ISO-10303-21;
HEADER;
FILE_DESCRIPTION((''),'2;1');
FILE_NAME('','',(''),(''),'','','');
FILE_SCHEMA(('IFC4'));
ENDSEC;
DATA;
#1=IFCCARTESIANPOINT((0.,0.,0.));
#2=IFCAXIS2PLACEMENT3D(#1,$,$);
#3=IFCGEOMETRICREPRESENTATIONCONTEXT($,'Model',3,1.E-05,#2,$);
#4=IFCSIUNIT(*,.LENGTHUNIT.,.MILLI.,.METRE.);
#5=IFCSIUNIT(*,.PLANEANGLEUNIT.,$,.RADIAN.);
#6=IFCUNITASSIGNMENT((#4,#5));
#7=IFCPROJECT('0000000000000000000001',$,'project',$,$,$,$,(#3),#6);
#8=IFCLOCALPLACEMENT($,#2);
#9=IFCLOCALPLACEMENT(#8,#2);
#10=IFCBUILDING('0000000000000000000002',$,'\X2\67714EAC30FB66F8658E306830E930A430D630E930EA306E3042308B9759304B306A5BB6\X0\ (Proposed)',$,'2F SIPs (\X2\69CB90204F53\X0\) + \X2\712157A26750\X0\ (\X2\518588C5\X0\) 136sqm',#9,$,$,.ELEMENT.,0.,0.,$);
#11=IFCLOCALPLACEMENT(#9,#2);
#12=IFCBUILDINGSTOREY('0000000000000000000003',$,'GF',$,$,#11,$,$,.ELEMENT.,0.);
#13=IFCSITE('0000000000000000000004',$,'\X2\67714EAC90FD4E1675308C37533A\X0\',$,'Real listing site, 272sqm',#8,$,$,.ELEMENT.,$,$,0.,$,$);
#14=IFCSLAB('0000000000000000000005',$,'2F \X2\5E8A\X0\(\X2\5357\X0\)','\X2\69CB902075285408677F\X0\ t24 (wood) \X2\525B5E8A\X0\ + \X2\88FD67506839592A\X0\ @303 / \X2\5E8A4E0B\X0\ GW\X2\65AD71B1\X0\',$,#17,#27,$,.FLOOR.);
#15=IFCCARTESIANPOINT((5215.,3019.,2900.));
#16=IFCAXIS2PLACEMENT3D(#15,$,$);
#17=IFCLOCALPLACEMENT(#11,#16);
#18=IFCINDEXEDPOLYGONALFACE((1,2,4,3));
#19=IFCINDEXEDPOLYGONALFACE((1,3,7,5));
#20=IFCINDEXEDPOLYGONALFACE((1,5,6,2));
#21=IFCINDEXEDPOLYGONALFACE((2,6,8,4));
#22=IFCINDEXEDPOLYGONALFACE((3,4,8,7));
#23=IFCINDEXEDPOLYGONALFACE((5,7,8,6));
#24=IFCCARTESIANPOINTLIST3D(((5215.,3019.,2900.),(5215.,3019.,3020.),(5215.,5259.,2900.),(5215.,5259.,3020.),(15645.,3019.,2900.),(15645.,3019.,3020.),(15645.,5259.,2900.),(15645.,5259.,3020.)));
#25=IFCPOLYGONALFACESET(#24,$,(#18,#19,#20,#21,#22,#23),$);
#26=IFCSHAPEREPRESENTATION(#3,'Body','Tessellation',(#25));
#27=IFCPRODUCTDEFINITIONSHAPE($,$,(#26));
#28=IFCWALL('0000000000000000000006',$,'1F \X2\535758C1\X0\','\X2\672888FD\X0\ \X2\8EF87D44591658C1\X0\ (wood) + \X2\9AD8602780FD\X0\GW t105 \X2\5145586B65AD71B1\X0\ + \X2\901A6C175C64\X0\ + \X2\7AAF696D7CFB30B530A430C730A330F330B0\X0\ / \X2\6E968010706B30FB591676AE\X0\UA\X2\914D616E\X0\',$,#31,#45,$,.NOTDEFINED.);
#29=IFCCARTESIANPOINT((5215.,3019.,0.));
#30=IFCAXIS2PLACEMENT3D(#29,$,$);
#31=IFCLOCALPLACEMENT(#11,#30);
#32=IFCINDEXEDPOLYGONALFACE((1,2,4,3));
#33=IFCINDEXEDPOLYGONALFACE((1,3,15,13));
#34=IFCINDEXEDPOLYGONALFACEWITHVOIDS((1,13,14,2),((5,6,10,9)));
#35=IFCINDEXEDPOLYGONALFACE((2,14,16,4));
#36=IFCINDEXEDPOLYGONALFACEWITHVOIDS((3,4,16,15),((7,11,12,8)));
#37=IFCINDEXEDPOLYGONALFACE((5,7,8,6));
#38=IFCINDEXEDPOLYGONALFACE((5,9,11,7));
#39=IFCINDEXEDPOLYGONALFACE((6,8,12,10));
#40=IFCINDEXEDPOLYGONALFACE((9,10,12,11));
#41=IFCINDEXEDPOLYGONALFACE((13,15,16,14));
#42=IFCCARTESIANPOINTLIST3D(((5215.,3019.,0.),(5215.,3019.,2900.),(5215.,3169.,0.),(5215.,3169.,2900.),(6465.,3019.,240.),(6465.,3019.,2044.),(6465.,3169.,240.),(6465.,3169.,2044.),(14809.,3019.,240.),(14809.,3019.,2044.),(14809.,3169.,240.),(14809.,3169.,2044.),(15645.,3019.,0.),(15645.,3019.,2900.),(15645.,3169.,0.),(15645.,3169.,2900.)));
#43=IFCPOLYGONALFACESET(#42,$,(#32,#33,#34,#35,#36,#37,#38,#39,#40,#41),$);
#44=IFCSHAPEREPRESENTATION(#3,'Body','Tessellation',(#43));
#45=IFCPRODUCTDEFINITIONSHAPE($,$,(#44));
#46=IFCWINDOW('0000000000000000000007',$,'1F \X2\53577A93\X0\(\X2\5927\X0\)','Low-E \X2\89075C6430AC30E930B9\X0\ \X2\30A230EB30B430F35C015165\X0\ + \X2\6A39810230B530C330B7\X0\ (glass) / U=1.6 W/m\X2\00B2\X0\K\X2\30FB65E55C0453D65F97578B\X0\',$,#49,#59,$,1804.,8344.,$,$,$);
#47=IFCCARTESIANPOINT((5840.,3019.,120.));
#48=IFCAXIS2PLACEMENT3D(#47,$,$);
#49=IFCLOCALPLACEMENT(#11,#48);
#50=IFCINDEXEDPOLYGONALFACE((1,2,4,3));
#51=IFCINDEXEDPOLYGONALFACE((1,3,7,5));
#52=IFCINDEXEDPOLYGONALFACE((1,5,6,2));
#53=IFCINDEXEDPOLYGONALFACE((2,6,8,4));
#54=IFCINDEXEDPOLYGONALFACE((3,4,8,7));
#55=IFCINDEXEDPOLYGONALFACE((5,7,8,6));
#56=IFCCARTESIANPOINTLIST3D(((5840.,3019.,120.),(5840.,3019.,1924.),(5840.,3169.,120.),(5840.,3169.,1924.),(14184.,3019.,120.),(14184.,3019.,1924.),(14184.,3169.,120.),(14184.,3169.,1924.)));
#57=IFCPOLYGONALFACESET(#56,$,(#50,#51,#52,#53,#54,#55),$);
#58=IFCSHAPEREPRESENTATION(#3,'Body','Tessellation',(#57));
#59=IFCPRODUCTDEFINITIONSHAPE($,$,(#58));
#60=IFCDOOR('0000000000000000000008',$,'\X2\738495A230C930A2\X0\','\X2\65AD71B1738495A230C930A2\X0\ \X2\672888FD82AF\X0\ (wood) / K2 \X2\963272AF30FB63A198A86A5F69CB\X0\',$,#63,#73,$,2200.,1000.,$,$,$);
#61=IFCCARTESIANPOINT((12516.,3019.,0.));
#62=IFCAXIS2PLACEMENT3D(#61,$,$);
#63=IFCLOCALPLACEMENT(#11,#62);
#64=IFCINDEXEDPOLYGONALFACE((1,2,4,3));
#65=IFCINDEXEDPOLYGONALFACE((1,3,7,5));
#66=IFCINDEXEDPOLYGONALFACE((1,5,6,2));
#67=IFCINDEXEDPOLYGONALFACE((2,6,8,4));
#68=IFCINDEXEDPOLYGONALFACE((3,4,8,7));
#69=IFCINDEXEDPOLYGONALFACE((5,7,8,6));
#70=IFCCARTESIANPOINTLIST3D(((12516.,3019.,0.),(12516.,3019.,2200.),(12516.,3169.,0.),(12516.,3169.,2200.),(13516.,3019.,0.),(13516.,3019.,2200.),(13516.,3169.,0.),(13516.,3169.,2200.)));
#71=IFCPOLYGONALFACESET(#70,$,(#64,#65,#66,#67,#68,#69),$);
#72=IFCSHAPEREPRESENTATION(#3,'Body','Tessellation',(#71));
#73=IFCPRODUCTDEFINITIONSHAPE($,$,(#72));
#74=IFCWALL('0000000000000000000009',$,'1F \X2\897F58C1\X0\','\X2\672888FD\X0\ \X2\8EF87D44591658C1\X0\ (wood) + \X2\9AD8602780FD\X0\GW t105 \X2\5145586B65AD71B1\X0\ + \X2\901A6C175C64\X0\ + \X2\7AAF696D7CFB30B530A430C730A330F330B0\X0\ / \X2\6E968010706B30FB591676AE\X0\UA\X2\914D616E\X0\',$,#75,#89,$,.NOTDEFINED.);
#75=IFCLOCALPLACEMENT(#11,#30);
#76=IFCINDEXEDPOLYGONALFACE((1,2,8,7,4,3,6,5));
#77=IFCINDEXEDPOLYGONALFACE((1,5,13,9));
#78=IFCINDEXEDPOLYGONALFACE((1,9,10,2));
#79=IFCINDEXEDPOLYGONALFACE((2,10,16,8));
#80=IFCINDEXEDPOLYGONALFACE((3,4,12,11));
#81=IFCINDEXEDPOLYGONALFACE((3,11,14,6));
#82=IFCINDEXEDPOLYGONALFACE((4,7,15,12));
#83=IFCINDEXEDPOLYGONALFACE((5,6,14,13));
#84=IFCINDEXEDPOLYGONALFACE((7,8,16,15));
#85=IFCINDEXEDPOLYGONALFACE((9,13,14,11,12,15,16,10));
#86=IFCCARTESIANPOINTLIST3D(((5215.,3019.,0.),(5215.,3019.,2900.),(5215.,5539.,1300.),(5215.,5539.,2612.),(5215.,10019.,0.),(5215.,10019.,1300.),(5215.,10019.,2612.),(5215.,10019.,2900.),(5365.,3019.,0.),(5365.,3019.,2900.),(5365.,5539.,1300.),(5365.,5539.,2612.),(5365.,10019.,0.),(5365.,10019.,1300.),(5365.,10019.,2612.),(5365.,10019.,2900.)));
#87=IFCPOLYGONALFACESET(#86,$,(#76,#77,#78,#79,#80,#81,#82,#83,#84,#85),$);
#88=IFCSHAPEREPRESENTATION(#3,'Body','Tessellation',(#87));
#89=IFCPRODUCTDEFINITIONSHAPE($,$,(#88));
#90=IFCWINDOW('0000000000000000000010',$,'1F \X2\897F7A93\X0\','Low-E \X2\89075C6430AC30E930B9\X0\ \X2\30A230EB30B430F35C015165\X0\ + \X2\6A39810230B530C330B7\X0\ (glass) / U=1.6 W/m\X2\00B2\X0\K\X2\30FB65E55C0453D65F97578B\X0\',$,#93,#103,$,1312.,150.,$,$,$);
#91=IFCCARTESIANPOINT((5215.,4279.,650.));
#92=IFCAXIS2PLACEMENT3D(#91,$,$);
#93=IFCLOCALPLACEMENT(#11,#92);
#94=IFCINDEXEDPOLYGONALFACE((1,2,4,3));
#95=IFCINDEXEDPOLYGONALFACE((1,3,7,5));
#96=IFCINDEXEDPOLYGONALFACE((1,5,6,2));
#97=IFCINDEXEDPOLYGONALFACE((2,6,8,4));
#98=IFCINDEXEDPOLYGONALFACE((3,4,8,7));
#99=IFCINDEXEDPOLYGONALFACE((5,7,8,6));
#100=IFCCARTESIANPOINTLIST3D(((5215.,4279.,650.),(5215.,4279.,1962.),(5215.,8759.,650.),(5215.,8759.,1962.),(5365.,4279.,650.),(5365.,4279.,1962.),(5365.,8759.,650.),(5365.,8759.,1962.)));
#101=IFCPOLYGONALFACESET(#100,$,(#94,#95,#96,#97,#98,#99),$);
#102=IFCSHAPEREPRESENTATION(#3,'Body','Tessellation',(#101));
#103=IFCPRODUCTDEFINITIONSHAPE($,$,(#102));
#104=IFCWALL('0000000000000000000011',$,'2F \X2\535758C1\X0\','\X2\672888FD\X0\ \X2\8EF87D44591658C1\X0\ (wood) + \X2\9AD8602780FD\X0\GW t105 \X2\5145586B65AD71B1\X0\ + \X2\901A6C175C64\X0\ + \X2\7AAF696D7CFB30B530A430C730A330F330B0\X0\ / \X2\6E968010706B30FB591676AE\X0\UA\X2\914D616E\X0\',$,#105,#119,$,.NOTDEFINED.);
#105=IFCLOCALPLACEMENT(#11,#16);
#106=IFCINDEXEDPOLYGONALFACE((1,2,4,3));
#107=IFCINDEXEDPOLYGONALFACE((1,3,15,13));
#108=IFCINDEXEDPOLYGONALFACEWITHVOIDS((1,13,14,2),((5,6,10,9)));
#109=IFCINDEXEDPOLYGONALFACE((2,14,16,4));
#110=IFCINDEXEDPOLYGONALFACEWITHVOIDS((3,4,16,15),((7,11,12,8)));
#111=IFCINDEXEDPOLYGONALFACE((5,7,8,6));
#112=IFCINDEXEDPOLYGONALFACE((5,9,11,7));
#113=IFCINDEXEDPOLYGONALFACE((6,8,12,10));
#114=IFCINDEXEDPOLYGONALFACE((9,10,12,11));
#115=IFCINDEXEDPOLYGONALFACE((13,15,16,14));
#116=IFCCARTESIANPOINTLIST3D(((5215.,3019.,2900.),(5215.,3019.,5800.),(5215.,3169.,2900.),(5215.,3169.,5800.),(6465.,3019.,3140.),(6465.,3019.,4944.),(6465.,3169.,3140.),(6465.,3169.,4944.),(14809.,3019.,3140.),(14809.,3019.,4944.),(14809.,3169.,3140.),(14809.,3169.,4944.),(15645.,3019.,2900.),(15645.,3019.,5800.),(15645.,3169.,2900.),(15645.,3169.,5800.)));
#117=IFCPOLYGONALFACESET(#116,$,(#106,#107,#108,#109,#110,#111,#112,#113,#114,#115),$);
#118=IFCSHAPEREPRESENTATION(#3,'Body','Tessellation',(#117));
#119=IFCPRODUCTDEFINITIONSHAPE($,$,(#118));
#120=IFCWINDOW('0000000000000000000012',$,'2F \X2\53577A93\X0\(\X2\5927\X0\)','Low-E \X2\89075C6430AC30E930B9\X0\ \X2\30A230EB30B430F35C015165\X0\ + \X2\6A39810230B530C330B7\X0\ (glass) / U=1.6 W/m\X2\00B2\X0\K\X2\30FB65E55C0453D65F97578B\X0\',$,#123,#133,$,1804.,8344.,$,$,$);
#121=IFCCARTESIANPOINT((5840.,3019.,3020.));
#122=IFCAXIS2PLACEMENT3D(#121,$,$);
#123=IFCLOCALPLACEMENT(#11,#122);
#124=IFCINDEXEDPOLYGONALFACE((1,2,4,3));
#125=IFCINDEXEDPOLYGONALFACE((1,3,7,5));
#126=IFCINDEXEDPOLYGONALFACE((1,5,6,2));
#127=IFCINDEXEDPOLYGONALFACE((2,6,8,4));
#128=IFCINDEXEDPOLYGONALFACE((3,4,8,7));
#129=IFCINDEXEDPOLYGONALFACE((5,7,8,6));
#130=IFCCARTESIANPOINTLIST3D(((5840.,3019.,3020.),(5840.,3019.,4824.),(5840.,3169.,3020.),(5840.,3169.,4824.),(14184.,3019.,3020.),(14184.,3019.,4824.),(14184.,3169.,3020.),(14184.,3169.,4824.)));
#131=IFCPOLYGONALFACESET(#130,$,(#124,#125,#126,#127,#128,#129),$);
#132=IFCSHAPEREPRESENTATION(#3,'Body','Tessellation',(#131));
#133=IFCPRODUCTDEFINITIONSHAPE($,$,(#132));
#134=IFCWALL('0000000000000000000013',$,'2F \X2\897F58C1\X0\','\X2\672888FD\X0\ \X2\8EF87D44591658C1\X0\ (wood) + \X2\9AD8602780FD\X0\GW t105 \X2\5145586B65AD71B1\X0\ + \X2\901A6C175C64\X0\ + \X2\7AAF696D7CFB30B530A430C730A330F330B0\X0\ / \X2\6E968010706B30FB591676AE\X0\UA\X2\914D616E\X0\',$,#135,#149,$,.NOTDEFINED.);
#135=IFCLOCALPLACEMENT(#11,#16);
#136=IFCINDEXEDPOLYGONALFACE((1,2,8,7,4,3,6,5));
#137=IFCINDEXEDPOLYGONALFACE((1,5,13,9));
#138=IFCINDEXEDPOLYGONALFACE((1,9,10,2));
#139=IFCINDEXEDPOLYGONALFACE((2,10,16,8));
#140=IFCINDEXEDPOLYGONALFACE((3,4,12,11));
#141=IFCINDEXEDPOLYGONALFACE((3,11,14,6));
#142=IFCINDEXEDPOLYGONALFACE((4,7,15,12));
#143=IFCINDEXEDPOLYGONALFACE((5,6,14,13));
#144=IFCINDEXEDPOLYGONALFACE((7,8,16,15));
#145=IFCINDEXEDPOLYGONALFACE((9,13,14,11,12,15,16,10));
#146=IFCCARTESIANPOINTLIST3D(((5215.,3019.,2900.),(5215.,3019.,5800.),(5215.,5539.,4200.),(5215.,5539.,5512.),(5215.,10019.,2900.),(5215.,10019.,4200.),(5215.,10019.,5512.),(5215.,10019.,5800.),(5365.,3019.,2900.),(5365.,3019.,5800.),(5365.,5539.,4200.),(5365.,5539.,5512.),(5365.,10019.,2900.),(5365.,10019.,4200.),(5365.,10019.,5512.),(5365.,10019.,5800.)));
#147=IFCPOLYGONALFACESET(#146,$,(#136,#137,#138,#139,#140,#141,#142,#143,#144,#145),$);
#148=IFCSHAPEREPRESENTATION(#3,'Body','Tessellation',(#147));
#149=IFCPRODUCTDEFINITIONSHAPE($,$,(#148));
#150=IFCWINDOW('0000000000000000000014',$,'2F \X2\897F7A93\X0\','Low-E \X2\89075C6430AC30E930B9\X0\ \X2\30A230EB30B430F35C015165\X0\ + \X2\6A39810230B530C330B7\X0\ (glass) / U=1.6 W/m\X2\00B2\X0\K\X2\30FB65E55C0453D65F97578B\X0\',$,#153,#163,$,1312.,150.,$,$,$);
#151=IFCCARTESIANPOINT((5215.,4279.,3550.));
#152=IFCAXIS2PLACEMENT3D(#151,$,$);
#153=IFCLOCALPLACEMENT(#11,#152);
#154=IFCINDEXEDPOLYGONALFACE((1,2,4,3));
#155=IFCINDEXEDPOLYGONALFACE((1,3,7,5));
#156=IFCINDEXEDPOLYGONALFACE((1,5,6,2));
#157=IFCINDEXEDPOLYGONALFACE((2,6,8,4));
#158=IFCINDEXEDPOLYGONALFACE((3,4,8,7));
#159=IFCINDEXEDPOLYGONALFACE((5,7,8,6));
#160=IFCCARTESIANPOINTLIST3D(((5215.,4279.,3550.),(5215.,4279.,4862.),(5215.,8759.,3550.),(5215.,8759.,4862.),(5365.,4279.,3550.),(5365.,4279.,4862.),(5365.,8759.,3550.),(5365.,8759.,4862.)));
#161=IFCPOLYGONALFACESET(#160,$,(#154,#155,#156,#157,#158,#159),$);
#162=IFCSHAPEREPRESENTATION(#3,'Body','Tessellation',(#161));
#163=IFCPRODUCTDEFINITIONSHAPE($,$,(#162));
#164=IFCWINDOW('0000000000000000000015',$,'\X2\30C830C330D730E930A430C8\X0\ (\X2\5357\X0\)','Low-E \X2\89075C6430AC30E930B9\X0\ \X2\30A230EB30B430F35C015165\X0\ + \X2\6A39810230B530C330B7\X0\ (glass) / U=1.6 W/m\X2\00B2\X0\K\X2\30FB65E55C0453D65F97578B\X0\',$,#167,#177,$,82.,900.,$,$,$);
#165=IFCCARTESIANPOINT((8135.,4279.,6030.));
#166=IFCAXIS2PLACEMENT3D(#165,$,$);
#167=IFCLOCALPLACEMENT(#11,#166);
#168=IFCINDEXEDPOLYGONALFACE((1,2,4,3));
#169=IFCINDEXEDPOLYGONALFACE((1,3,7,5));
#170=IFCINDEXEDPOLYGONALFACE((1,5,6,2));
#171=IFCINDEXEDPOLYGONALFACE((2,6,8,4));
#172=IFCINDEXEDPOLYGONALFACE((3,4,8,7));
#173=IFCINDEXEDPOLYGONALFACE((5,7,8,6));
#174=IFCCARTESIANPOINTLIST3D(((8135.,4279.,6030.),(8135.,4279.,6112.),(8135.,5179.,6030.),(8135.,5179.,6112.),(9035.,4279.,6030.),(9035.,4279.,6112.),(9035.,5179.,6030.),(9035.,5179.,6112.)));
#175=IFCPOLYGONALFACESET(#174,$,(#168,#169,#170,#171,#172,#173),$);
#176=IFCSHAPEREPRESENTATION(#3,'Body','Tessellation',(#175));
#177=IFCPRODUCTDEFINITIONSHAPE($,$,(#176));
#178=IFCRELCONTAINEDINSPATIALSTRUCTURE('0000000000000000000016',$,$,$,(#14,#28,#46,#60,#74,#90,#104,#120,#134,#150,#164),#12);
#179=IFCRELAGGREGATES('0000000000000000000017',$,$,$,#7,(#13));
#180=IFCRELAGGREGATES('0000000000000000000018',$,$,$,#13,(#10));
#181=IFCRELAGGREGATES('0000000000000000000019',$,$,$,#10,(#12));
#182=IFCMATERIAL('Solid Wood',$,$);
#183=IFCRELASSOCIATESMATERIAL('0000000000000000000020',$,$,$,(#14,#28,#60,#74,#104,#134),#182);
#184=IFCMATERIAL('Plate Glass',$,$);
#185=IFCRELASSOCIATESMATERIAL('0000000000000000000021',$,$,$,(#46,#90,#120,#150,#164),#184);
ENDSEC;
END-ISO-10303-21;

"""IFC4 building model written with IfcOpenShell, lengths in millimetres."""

from ifc_helpers import new_model, si_unit, frame, frame_2d, origin, place, context, project, spatial, rectangle, extrude, material, element, fill, save


model = new_model("IFC4")

# Units and contexts
model_context = context("Model", 3, precision=1e-05, world=origin())
ifc_project = project(units=[si_unit("LENGTHUNIT", "METRE", prefix="MILLI"), si_unit("PLANEANGLEUNIT", "RADIAN")], contexts=[model_context])

# Site, building, storey
site_placement = place(None, origin())
site = spatial("IfcSite", under=ifc_project, at=site_placement, Name="東京都世田谷区", ObjectType="Real listing site, 272sqm", CompositionType="ELEMENT", RefElevation=0.0)
building_placement = place(site_placement, origin())
building = spatial("IfcBuilding", under=site, at=building_placement, Name="東京・書斎とライブラリのある静かな家 (Proposed)", ObjectType="2F SIPs (構造体) + 無垢材 (内装) 136sqm", CompositionType="ELEMENT", ElevationOfRefHeight=0.0, ElevationOfTerrain=0.0)
storey_placement = place(building_placement, origin())
storey = spatial("IfcBuildingStorey", under=building, at=storey_placement, Name="GF", CompositionType="ELEMENT", Elevation=0.0)

# Slab
ifc_material_1 = material(Name="Solid Wood")
slab_1_placement = place(storey_placement, frame((5215.0, 3019.0, 2900.0)))
element("IfcSlab", 1, at=slab_1_placement, inside=storey, material=ifc_material_1, Name="2F 床(南)", Description="構造用合板 t24 (wood) 剛床 + 製材根太 @303 / 床下 GW断熱", PredefinedType="FLOOR", context=model_context, shape_type="SweptSolid", body=[
    extrude(rectangle(XDim=10430.0, YDim=2240.0, at=frame_2d((5215.0, 1120.0))), frame((5215.0, 3019.0, 2900.0)), (0.0, 0.0, 1.0), 120.0),
])

# Wall, openings, window, door
wall_1_placement = place(storey_placement, frame((5215.0, 3019.0, 0.0)))
wall_1 = element("IfcWall", 2, at=wall_1_placement, inside=storey, material=ifc_material_1, Name="1F 南壁", Description="木製 軸組外壁 (wood) + 高性能GW t105 充填断熱 + 通気層 + 窯業系サイディング / 準耐火・外皮UA配慮", PredefinedType="NOTDEFINED", context=model_context, shape_type="SweptSolid", body=[
    extrude(rectangle(XDim=10430.0, YDim=150.0, at=frame_2d((5215.0, 75.0))), frame((5215.0, 3019.0, 0.0)), (0.0, 0.0, 1.0), 2900.0),
])
opening_1_placement = place(storey_placement, frame((5840.0, 3019.0, 120.0)))
opening_1 = element("IfcOpeningElement", 3, at=opening_1_placement, cuts=wall_1, PredefinedType="NOTDEFINED", context=model_context, shape_type="SweptSolid", body=[
    extrude(rectangle(XDim=8344.0, YDim=150.0, at=frame_2d((4172.0, 75.0))), frame((5840.0, 3019.0, 120.0)), (0.0, 0.0, 1.0), 1804.0),
])
opening_2_placement = place(storey_placement, frame((12516.0, 3019.0, 0.0)))
opening_2 = element("IfcOpeningElement", 4, at=opening_2_placement, cuts=wall_1, PredefinedType="NOTDEFINED", context=model_context, shape_type="SweptSolid", body=[
    extrude(rectangle(XDim=1000.0, YDim=150.0, at=frame_2d((500.0, 75.0))), frame((12516.0, 3019.0, 0.0)), (0.0, 0.0, 1.0), 2200.0),
])
ifc_material_2 = material(Name="Plate Glass")
window_1_placement = place(storey_placement, frame((5840.0, 3019.0, 120.0)))
window_1 = element("IfcWindow", 5, at=window_1_placement, inside=storey, material=ifc_material_2, Name="1F 南窓(大)", Description="Low-E 複層ガラス アルゴン封入 + 樹脂サッシ (glass) / U=1.6 W/m²K・日射取得型", OverallHeight=1804.0, OverallWidth=8344.0, context=model_context, shape_type="SweptSolid", body=[
    extrude(rectangle(XDim=8344.0, YDim=150.0, at=frame_2d((4172.0, 75.0))), frame((5840.0, 3019.0, 120.0)), (0.0, 0.0, 1.0), 1804.0),
])
fill(opening_1, window_1)
door_placement = place(storey_placement, frame((12516.0, 3019.0, 0.0)))
door = element("IfcDoor", 6, at=door_placement, inside=storey, material=ifc_material_1, Name="玄関ドア", Description="断熱玄関ドア 木製芯 (wood) / K2 防犯・採風機構", OverallHeight=2200.0, OverallWidth=1000.0, context=model_context, shape_type="SweptSolid", body=[
    extrude(rectangle(XDim=1000.0, YDim=150.0, at=frame_2d((500.0, 75.0))), frame((12516.0, 3019.0, 0.0)), (0.0, 0.0, 1.0), 2200.0),
])
fill(opening_2, door)

# Walls, openings, windows
wall_2_placement = place(storey_placement, frame((5215.0, 3019.0, 0.0)))
wall_2 = element("IfcWall", 7, at=wall_2_placement, inside=storey, material=ifc_material_1, Name="1F 西壁", Description="木製 軸組外壁 (wood) + 高性能GW t105 充填断熱 + 通気層 + 窯業系サイディング / 準耐火・外皮UA配慮", PredefinedType="NOTDEFINED", context=model_context, shape_type="SweptSolid", body=[
    extrude(rectangle(XDim=150.0, YDim=7000.0, at=frame_2d((75.0, 3500.0))), frame((5215.0, 3019.0, 0.0)), (0.0, 0.0, 1.0), 2900.0),
])
opening_3_placement = place(storey_placement, frame((5215.0, 4279.0, 650.0)))
opening_3 = element("IfcOpeningElement", 8, at=opening_3_placement, cuts=wall_2, PredefinedType="NOTDEFINED", context=model_context, shape_type="SweptSolid", body=[
    extrude(rectangle(XDim=150.0, YDim=4480.0, at=frame_2d((75.0, 2240.0))), frame((5215.0, 4279.0, 650.0)), (0.0, 0.0, 1.0), 1312.0),
])
window_2_placement = place(storey_placement, frame((5215.0, 4279.0, 650.0)))
window_2 = element("IfcWindow", 9, at=window_2_placement, inside=storey, material=ifc_material_2, Name="1F 西窓", Description="Low-E 複層ガラス アルゴン封入 + 樹脂サッシ (glass) / U=1.6 W/m²K・日射取得型", OverallHeight=1312.0, OverallWidth=150.0, context=model_context, shape_type="SweptSolid", body=[
    extrude(rectangle(XDim=150.0, YDim=4480.0, at=frame_2d((75.0, 2240.0))), frame((5215.0, 4279.0, 650.0)), (0.0, 0.0, 1.0), 1312.0),
])
fill(opening_3, window_2)
wall_3_placement = place(storey_placement, frame((5215.0, 3019.0, 2900.0)))
wall_3 = element("IfcWall", 10, at=wall_3_placement, inside=storey, material=ifc_material_1, Name="2F 南壁", Description="木製 軸組外壁 (wood) + 高性能GW t105 充填断熱 + 通気層 + 窯業系サイディング / 準耐火・外皮UA配慮", PredefinedType="NOTDEFINED", context=model_context, shape_type="SweptSolid", body=[
    extrude(rectangle(XDim=10430.0, YDim=150.0, at=frame_2d((5215.0, 75.0))), frame((5215.0, 3019.0, 2900.0)), (0.0, 0.0, 1.0), 2900.0),
])
opening_4_placement = place(storey_placement, frame((5840.0, 3019.0, 3020.0)))
opening_4 = element("IfcOpeningElement", 11, at=opening_4_placement, cuts=wall_3, PredefinedType="NOTDEFINED", context=model_context, shape_type="SweptSolid", body=[
    extrude(rectangle(XDim=8344.0, YDim=150.0, at=frame_2d((4172.0, 75.0))), frame((5840.0, 3019.0, 3020.0)), (0.0, 0.0, 1.0), 1804.0),
])
window_3_placement = place(storey_placement, frame((5840.0, 3019.0, 3020.0)))
window_3 = element("IfcWindow", 12, at=window_3_placement, inside=storey, material=ifc_material_2, Name="2F 南窓(大)", Description="Low-E 複層ガラス アルゴン封入 + 樹脂サッシ (glass) / U=1.6 W/m²K・日射取得型", OverallHeight=1804.0, OverallWidth=8344.0, context=model_context, shape_type="SweptSolid", body=[
    extrude(rectangle(XDim=8344.0, YDim=150.0, at=frame_2d((4172.0, 75.0))), frame((5840.0, 3019.0, 3020.0)), (0.0, 0.0, 1.0), 1804.0),
])
fill(opening_4, window_3)
wall_4_placement = place(storey_placement, frame((5215.0, 3019.0, 2900.0)))
wall_4 = element("IfcWall", 13, at=wall_4_placement, inside=storey, material=ifc_material_1, Name="2F 西壁", Description="木製 軸組外壁 (wood) + 高性能GW t105 充填断熱 + 通気層 + 窯業系サイディング / 準耐火・外皮UA配慮", PredefinedType="NOTDEFINED", context=model_context, shape_type="SweptSolid", body=[
    extrude(rectangle(XDim=150.0, YDim=7000.0, at=frame_2d((75.0, 3500.0))), frame((5215.0, 3019.0, 2900.0)), (0.0, 0.0, 1.0), 2900.0),
])
opening_5_placement = place(storey_placement, frame((5215.0, 4279.0, 3550.0)))
opening_5 = element("IfcOpeningElement", 14, at=opening_5_placement, cuts=wall_4, PredefinedType="NOTDEFINED", context=model_context, shape_type="SweptSolid", body=[
    extrude(rectangle(XDim=150.0, YDim=4480.0, at=frame_2d((75.0, 2240.0))), frame((5215.0, 4279.0, 3550.0)), (0.0, 0.0, 1.0), 1312.0),
])
window_4_placement = place(storey_placement, frame((5215.0, 4279.0, 3550.0)))
window_4 = element("IfcWindow", 15, at=window_4_placement, inside=storey, material=ifc_material_2, Name="2F 西窓", Description="Low-E 複層ガラス アルゴン封入 + 樹脂サッシ (glass) / U=1.6 W/m²K・日射取得型", OverallHeight=1312.0, OverallWidth=150.0, context=model_context, shape_type="SweptSolid", body=[
    extrude(rectangle(XDim=150.0, YDim=4480.0, at=frame_2d((75.0, 2240.0))), frame((5215.0, 4279.0, 3550.0)), (0.0, 0.0, 1.0), 1312.0),
])
fill(opening_5, window_4)

# Window
window_5_placement = place(storey_placement, frame((8135.0, 4279.0, 6030.0)))
element("IfcWindow", 16, at=window_5_placement, inside=storey, material=ifc_material_2, Name="トップライト (南)", Description="Low-E 複層ガラス アルゴン封入 + 樹脂サッシ (glass) / U=1.6 W/m²K・日射取得型", OverallHeight=82.0, OverallWidth=900.0, context=model_context, shape_type="SweptSolid", body=[
    extrude(rectangle(XDim=900.0, YDim=900.0, at=frame_2d((450.0, 450.0))), frame((8135.0, 4279.0, 6030.0)), (0.0, 0.0, 1.0), 82.0),
])

save(model, "model.ifc")
